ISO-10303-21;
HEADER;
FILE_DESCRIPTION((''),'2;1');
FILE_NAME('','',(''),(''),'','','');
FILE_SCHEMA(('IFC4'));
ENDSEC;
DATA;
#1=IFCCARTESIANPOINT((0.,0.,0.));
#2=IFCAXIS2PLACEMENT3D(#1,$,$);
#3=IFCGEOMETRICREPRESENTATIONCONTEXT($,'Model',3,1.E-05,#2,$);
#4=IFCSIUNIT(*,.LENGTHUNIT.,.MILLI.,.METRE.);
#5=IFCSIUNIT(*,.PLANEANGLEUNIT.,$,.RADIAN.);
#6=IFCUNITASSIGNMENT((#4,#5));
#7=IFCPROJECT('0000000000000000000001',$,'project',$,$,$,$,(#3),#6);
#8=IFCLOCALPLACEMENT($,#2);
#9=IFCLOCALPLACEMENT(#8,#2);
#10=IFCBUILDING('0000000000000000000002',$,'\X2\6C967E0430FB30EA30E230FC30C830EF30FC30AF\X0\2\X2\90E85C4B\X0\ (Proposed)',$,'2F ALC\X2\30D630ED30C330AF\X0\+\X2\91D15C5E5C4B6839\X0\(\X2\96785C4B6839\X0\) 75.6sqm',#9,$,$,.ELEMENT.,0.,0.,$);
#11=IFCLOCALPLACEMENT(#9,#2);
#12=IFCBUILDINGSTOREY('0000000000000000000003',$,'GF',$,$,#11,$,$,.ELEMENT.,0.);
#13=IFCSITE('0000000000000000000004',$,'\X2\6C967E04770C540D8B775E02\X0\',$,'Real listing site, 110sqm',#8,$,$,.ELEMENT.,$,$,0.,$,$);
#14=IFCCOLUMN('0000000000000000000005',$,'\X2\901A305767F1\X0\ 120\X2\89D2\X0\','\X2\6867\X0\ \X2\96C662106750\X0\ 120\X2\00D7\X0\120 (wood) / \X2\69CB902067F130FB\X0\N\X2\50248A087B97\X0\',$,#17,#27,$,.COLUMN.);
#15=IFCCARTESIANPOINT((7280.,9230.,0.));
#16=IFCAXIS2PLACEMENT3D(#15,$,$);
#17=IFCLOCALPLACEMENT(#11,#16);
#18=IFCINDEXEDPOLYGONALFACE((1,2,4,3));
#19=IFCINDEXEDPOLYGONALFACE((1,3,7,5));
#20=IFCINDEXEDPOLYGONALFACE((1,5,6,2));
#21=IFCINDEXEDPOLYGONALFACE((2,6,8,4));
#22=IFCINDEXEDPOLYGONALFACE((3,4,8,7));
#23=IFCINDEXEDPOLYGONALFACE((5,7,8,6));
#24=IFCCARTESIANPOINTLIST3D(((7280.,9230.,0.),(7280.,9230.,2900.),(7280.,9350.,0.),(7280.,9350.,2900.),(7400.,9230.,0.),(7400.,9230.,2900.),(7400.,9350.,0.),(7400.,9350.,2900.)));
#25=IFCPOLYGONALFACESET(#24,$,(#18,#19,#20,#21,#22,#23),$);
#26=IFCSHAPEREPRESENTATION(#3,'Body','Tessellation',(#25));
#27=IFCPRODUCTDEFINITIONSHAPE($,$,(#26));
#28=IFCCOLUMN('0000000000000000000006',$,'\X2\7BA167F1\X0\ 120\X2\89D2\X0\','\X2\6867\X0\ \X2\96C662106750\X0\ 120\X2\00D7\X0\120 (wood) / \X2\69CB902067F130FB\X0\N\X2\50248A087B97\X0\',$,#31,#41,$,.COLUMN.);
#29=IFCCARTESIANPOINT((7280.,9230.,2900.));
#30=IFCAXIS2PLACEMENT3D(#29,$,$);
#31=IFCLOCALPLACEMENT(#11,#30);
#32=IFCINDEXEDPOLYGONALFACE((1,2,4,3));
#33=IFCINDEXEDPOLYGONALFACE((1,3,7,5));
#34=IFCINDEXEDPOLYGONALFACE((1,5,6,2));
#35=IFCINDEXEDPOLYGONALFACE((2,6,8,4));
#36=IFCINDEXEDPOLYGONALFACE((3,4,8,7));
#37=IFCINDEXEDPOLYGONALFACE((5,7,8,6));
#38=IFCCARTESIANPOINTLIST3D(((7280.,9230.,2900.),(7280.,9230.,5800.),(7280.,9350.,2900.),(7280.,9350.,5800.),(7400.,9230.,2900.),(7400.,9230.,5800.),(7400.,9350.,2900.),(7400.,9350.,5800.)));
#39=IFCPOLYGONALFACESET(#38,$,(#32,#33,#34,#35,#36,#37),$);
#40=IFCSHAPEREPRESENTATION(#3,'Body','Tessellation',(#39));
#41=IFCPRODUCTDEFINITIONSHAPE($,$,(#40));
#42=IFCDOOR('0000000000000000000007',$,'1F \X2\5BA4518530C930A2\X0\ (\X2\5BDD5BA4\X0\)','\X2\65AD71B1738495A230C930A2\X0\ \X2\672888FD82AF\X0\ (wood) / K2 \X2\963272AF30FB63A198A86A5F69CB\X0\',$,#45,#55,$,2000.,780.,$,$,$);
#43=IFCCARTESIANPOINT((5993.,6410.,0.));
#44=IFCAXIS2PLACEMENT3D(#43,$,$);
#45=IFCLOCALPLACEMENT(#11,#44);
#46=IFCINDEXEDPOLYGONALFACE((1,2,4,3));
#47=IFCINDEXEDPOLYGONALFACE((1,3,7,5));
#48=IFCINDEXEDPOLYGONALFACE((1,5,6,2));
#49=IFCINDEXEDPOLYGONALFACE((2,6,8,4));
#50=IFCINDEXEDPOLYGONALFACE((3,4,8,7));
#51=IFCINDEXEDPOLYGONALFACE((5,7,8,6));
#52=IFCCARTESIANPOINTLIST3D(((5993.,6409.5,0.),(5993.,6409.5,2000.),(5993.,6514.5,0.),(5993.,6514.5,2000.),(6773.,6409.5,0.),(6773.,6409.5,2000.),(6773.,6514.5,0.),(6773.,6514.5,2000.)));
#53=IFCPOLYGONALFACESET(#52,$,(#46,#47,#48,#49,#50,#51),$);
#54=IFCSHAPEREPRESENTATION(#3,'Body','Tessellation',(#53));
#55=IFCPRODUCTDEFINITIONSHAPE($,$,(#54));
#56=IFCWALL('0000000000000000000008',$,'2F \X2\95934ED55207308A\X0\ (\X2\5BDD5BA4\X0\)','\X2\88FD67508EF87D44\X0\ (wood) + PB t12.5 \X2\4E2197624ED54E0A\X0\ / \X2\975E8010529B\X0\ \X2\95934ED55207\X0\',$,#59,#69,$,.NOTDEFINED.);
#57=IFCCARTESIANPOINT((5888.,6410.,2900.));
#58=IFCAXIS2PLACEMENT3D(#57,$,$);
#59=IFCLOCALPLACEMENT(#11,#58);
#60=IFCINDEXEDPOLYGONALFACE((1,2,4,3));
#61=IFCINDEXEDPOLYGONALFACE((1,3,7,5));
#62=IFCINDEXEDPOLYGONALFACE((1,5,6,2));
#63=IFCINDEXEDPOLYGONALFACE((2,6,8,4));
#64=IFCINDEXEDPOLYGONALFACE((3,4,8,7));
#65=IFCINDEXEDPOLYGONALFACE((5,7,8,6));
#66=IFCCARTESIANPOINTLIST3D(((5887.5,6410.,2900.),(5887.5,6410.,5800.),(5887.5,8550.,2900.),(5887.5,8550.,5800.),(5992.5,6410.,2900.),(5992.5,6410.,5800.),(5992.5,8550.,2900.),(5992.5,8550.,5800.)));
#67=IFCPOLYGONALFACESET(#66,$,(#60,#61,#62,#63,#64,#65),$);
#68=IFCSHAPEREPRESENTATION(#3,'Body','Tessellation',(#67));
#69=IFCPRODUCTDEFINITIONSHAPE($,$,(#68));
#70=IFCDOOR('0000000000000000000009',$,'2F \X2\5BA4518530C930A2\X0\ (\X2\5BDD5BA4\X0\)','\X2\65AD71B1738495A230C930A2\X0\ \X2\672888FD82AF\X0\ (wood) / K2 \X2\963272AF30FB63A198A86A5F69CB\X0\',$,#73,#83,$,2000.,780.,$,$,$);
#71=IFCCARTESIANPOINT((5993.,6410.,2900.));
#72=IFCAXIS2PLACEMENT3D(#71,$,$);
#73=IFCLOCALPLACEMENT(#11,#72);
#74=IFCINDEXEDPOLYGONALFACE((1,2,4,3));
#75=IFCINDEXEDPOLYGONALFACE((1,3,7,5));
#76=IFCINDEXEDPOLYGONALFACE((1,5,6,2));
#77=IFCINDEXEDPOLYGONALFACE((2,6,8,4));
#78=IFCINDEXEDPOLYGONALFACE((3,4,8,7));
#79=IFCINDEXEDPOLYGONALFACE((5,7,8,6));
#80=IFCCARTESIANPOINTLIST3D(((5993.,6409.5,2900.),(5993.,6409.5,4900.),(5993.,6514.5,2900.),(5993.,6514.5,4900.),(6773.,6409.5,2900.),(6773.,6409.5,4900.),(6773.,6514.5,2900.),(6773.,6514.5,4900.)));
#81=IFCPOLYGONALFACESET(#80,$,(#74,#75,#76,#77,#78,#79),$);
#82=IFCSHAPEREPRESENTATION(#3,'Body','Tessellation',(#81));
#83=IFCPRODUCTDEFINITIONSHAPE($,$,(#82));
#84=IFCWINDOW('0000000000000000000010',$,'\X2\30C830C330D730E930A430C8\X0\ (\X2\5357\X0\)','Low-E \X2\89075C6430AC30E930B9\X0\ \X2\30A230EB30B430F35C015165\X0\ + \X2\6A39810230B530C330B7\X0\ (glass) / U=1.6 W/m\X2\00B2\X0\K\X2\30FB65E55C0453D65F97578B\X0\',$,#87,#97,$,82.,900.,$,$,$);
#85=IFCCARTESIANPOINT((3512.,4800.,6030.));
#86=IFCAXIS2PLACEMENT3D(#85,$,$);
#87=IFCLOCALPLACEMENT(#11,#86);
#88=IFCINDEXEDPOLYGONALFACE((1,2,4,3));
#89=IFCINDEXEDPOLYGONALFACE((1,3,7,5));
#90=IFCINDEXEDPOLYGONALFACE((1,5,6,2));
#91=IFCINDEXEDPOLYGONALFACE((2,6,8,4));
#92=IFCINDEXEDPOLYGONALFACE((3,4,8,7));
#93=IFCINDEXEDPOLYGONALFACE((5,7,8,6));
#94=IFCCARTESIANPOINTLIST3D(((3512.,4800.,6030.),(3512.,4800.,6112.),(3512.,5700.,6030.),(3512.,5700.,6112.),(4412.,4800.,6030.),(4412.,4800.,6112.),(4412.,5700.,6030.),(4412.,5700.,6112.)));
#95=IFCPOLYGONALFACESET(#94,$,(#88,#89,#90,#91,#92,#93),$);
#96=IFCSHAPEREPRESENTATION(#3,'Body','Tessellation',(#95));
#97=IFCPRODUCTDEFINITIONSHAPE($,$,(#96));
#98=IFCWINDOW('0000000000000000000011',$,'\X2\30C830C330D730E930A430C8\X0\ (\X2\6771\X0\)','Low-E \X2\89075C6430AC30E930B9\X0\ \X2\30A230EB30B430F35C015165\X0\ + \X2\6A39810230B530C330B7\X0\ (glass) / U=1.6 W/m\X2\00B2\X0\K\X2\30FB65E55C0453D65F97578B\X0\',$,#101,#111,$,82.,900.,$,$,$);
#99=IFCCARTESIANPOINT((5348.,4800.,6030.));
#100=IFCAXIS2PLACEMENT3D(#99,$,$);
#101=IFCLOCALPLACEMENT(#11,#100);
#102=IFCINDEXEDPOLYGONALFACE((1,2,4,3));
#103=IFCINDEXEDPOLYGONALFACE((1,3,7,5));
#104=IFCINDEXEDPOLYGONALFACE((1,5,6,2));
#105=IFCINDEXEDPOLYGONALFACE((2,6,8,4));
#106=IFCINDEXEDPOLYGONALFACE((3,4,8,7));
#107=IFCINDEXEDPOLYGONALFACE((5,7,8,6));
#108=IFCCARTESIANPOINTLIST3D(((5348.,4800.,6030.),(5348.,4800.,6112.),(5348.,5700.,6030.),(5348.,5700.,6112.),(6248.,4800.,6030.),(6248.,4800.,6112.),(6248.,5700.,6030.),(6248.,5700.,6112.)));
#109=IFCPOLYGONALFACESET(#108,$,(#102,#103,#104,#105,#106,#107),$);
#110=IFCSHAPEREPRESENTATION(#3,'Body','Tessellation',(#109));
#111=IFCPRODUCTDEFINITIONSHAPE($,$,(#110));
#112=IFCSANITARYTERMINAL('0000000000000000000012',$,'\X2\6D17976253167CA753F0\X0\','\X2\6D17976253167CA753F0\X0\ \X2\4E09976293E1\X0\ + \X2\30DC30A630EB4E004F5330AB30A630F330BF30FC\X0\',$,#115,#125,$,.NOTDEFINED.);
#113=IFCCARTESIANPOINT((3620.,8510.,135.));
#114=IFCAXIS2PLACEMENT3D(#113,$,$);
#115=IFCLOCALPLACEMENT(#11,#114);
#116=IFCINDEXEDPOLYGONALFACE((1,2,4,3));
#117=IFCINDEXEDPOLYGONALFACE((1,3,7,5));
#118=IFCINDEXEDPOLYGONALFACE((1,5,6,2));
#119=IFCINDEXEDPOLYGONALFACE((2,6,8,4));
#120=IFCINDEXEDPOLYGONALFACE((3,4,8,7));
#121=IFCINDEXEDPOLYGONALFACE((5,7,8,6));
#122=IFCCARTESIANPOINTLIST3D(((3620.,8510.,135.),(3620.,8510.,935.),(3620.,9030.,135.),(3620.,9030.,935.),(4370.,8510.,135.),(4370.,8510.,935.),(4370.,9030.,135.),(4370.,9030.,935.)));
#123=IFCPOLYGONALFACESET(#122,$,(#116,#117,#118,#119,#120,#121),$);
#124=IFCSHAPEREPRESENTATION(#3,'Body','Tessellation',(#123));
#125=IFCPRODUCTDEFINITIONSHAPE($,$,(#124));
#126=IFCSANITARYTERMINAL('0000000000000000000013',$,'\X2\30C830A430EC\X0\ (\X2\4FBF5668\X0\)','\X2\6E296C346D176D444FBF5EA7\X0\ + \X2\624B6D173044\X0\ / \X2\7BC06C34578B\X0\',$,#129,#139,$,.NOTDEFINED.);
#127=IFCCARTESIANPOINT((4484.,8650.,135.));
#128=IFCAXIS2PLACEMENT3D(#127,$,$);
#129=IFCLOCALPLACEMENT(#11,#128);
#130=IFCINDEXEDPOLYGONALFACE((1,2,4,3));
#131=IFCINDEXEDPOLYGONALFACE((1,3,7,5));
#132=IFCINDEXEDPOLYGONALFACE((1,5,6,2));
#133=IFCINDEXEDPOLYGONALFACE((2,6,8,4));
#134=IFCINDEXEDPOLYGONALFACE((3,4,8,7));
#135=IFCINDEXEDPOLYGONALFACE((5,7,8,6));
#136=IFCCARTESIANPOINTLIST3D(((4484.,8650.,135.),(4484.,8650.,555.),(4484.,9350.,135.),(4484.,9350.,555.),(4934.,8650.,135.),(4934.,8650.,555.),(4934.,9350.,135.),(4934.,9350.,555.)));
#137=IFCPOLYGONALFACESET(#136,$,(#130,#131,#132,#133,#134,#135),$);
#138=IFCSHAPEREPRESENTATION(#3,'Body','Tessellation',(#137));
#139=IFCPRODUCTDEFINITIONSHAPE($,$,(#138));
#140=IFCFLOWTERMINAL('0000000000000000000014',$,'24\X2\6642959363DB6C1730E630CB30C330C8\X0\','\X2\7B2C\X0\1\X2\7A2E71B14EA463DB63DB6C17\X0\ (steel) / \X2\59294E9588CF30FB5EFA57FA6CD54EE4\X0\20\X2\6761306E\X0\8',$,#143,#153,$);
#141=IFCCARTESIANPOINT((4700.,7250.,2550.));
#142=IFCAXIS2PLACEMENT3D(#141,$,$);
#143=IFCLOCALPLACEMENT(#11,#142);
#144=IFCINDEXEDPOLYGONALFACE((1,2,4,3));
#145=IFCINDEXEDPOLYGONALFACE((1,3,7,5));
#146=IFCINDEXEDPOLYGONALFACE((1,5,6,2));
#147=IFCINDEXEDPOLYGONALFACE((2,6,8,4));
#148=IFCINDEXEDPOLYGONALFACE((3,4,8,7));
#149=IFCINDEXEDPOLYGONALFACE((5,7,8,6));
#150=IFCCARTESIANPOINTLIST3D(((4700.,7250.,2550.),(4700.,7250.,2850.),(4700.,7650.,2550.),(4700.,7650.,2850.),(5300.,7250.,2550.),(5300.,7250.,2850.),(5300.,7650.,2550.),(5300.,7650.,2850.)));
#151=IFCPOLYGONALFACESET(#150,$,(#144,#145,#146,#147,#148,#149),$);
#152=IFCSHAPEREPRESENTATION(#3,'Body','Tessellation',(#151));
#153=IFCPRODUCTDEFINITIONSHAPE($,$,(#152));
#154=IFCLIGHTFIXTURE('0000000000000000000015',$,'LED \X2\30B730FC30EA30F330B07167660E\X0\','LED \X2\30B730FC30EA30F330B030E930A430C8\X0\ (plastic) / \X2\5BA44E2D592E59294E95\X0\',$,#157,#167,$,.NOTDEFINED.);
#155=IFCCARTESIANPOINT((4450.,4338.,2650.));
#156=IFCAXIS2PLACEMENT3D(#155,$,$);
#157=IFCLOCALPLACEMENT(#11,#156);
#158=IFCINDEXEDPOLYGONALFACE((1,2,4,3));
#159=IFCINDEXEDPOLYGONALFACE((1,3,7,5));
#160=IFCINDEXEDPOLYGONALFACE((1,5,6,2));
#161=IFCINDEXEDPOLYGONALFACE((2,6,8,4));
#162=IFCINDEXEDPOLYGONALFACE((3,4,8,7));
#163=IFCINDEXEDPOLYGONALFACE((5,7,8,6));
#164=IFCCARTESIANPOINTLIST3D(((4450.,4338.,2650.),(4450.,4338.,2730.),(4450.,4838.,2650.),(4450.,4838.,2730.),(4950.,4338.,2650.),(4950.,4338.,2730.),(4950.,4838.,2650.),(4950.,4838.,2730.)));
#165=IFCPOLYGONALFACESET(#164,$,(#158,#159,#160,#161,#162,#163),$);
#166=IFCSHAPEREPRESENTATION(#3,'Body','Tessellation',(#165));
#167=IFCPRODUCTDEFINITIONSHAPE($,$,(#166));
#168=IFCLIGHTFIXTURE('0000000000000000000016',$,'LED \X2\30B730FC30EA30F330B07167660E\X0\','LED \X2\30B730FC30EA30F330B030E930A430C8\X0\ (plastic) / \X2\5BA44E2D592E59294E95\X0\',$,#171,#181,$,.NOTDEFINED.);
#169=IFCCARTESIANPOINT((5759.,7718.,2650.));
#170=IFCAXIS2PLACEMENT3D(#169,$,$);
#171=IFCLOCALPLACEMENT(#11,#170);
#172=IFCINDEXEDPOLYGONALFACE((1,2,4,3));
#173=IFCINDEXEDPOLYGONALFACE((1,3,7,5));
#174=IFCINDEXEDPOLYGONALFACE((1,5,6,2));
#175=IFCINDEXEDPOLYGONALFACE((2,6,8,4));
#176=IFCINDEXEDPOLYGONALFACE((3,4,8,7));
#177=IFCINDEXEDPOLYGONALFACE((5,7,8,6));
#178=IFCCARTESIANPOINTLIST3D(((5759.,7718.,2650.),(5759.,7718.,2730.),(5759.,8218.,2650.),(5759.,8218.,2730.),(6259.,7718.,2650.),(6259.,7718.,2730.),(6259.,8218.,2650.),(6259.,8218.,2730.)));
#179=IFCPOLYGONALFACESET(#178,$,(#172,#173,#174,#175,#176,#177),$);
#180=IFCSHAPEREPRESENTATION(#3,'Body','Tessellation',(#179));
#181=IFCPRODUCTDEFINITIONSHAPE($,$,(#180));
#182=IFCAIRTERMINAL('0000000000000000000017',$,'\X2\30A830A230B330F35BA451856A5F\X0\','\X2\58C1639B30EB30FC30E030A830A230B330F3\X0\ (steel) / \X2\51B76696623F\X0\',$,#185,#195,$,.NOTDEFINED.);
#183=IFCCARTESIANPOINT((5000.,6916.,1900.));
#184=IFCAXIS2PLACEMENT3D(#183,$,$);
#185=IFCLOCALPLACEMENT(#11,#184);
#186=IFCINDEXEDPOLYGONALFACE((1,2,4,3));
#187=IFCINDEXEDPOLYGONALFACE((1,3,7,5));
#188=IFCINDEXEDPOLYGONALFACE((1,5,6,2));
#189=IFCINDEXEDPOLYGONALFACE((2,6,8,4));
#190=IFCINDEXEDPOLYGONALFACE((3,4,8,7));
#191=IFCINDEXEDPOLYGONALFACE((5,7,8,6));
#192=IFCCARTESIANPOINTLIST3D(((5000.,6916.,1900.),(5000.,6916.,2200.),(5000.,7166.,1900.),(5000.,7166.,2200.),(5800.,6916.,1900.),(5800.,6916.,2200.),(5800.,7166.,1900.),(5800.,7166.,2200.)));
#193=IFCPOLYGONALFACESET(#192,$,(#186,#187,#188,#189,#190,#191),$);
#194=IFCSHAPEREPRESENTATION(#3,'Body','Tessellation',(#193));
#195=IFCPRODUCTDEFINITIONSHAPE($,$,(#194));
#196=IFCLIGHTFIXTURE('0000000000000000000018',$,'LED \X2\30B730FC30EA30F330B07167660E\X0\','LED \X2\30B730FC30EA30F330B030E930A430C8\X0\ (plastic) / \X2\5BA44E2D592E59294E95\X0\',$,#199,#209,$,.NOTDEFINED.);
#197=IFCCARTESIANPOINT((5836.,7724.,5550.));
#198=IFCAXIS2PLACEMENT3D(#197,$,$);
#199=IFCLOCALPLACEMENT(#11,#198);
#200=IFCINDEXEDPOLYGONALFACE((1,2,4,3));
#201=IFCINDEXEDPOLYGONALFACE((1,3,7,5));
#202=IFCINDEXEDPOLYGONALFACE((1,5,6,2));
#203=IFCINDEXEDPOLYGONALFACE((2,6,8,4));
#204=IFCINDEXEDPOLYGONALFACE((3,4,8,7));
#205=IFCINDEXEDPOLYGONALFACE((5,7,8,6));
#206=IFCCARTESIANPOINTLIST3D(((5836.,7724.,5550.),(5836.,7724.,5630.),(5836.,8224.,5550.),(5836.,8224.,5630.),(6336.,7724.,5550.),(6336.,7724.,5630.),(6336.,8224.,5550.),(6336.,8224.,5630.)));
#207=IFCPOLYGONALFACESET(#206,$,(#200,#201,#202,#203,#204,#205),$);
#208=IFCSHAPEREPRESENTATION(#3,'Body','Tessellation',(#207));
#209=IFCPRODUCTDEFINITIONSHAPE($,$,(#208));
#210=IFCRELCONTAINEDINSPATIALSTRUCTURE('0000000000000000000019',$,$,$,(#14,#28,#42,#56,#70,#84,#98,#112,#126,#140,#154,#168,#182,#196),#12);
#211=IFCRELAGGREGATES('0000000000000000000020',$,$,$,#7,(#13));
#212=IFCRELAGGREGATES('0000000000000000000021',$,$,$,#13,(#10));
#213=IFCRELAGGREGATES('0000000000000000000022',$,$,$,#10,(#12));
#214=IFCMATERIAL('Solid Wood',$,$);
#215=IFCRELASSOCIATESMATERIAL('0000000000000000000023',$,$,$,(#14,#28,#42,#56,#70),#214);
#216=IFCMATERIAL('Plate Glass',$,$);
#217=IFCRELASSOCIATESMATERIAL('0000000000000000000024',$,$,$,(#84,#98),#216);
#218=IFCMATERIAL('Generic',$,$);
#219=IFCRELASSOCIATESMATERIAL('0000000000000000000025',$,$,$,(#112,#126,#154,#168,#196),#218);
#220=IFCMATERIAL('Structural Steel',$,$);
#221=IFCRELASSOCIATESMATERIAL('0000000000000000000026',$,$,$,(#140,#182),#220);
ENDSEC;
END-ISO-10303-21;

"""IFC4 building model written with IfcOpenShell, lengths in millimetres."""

from ifc_helpers import new_model, si_unit, frame, frame_2d, origin, place, context, project, spatial, rectangle, extrude, material, element, save


model = new_model("IFC4")

# Units and contexts
model_context = context("Model", 3, precision=1e-05, world=origin())
ifc_project = project(units=[si_unit("LENGTHUNIT", "METRE", prefix="MILLI"), si_unit("PLANEANGLEUNIT", "RADIAN")], contexts=[model_context])

# Site, building, storey
site_placement = place(None, origin())
site = spatial("IfcSite", under=ifc_project, at=site_placement, Name="沖縄県名護市", ObjectType="Real listing site, 110sqm", CompositionType="ELEMENT", RefElevation=0.0)
building_placement = place(site_placement, origin())
building = spatial("IfcBuilding", under=site, at=building_placement, Name="沖縄・リモートワーク2部屋 (Proposed)", ObjectType="2F ALCブロック+金属屋根(陸屋根) 75.6sqm", CompositionType="ELEMENT", ElevationOfRefHeight=0.0, ElevationOfTerrain=0.0)
storey_placement = place(building_placement, origin())
storey = spatial("IfcBuildingStorey", under=building, at=storey_placement, Name="GF", CompositionType="ELEMENT", Elevation=0.0)

# Columns
ifc_material_1 = material(Name="Solid Wood")
column_1_placement = place(storey_placement, frame((7280.0, 9230.0, 0.0)))
element("IfcColumn", 1, at=column_1_placement, inside=storey, material=ifc_material_1, Name="通し柱 120角", Description="桧 集成材 120×120 (wood) / 構造柱・N値計算", PredefinedType="COLUMN", context=model_context, shape_type="SweptSolid", body=[
    extrude(rectangle(XDim=120.0, YDim=120.0, at=frame_2d((60.0, 60.0))), frame((7280.0, 9230.0, 0.0)), (0.0, 0.0, 1.0), 2900.0),
])
column_2_placement = place(storey_placement, frame((7280.0, 9230.0, 2900.0)))
element("IfcColumn", 2, at=column_2_placement, inside=storey, material=ifc_material_1, Name="管柱 120角", Description="桧 集成材 120×120 (wood) / 構造柱・N値計算", PredefinedType="COLUMN", context=model_context, shape_type="SweptSolid", body=[
    extrude(rectangle(XDim=120.0, YDim=120.0, at=frame_2d((60.0, 60.0))), frame((7280.0, 9230.0, 2900.0)), (0.0, 0.0, 1.0), 2900.0),
])

# Door
door_1_placement = place(storey_placement, frame((5993.0, 6410.0, 0.0)))
element("IfcDoor", 3, at=door_1_placement, inside=storey, material=ifc_material_1, Name="1F 室内ドア (寝室)", Description="断熱玄関ドア 木製芯 (wood) / K2 防犯・採風機構", OverallHeight=2000.0, OverallWidth=780.0, context=model_context, shape_type="SweptSolid", body=[
    extrude(rectangle(XDim=780.0, YDim=105.0, at=frame_2d((390.0, 52.0))), frame((5993.0, 6410.0, 0.0)), (0.0, 0.0, 1.0), 2000.0),
])

# Wall
wall_1_placement = place(storey_placement, frame((5888.0, 6410.0, 2900.0)))
element("IfcWall", 4, at=wall_1_placement, inside=storey, material=ifc_material_1, Name="2F 間仕切り (寝室)", Description="製材軸組 (wood) + PB t12.5 両面仕上 / 非耐力 間仕切", PredefinedType="NOTDEFINED", context=model_context, shape_type="SweptSolid", body=[
    extrude(rectangle(XDim=105.0, YDim=2140.0, at=frame_2d((52.0, 1070.0))), frame((5888.0, 6410.0, 2900.0)), (0.0, 0.0, 1.0), 2900.0),
])

# Door
door_2_placement = place(storey_placement, frame((5993.0, 6410.0, 2900.0)))
element("IfcDoor", 5, at=door_2_placement, inside=storey, material=ifc_material_1, Name="2F 室内ドア (寝室)", Description="断熱玄関ドア 木製芯 (wood) / K2 防犯・採風機構", OverallHeight=2000.0, OverallWidth=780.0, context=model_context, shape_type="SweptSolid", body=[
    extrude(rectangle(XDim=780.0, YDim=105.0, at=frame_2d((390.0, 52.0))), frame((5993.0, 6410.0, 2900.0)), (0.0, 0.0, 1.0), 2000.0),
])

# Windows
ifc_material_2 = material(Name="Plate Glass")
window_1_placement = place(storey_placement, frame((3512.0, 4800.0, 6030.0)))
element("IfcWindow", 6, at=window_1_placement, inside=storey, material=ifc_material_2, Name="トップライト (南)", Description="Low-E 複層ガラス アルゴン封入 + 樹脂サッシ (glass) / U=1.6 W/m²K・日射取得型", OverallHeight=82.0, OverallWidth=900.0, context=model_context, shape_type="SweptSolid", body=[
    extrude(rectangle(XDim=900.0, YDim=900.0, at=frame_2d((450.0, 450.0))), frame((3512.0, 4800.0, 6030.0)), (0.0, 0.0, 1.0), 82.0),
])
window_2_placement = place(storey_placement, frame((5348.0, 4800.0, 6030.0)))
element("IfcWindow", 7, at=window_2_placement, inside=storey, material=ifc_material_2, Name="トップライト (東)", Description="Low-E 複層ガラス アルゴン封入 + 樹脂サッシ (glass) / U=1.6 W/m²K・日射取得型", OverallHeight=82.0, OverallWidth=900.0, context=model_context, shape_type="SweptSolid", body=[
    extrude(rectangle(XDim=900.0, YDim=900.0, at=frame_2d((450.0, 450.0))), frame((5348.0, 4800.0, 6030.0)), (0.0, 0.0, 1.0), 82.0),
])

# Sanitary terminals
ifc_material_3 = material(Name="Generic")
sanitary_terminal_1_placement = place(storey_placement, frame((3620.0, 8510.0, 135.0)))
element("IfcSanitaryTerminal", 8, at=sanitary_terminal_1_placement, inside=storey, material=ifc_material_3, Name="洗面化粧台", Description="洗面化粧台 三面鏡 + ボウル一体カウンター", PredefinedType="NOTDEFINED", context=model_context, shape_type="SweptSolid", body=[
    extrude(rectangle(XDim=750.0, YDim=520.0, at=frame_2d((375.0, 260.0))), frame((3620.0, 8510.0, 135.0)), (0.0, 0.0, 1.0), 800.0),
])
sanitary_terminal_2_placement = place(storey_placement, frame((4484.0, 8650.0, 135.0)))
element("IfcSanitaryTerminal", 9, at=sanitary_terminal_2_placement, inside=storey, material=ifc_material_3, Name="トイレ (便器)", Description="温水洗浄便座 + 手洗い / 節水型", PredefinedType="NOTDEFINED", context=model_context, shape_type="SweptSolid", body=[
    extrude(rectangle(XDim=450.0, YDim=700.0, at=frame_2d((225.0, 350.0))), frame((4484.0, 8650.0, 135.0)), (0.0, 0.0, 1.0), 420.0),
])

# Flow terminal
ifc_material_4 = material(Name="Structural Steel")
flow_terminal_placement = place(storey_placement, frame((4700.0, 7250.0, 2550.0)))
element("IfcFlowTerminal", 10, at=flow_terminal_placement, inside=storey, material=ifc_material_4, Name="24時間換気ユニット", Description="第1種熱交換換気 (steel) / 天井裏・建基法令20条の8", context=model_context, shape_type="SweptSolid", body=[
    extrude(rectangle(XDim=600.0, YDim=400.0, at=frame_2d((300.0, 200.0))), frame((4700.0, 7250.0, 2550.0)), (0.0, 0.0, 1.0), 300.0),
])

# Light fixtures
light_fixture_1_placement = place(storey_placement, frame((4450.0, 4338.0, 2650.0)))
element("IfcLightFixture", 11, at=light_fixture_1_placement, inside=storey, material=ifc_material_3, Name="LED シーリング照明", Description="LED シーリングライト (plastic) / 室中央天井", PredefinedType="NOTDEFINED", context=model_context, shape_type="SweptSolid", body=[
    extrude(rectangle(XDim=500.0, YDim=500.0, at=frame_2d((250.0, 250.0))), frame((4450.0, 4338.0, 2650.0)), (0.0, 0.0, 1.0), 80.0),
])
light_fixture_2_placement = place(storey_placement, frame((5759.0, 7718.0, 2650.0)))
element("IfcLightFixture", 12, at=light_fixture_2_placement, inside=storey, material=ifc_material_3, Name="LED シーリング照明", Description="LED シーリングライト (plastic) / 室中央天井", PredefinedType="NOTDEFINED", context=model_context, shape_type="SweptSolid", body=[
    extrude(rectangle(XDim=500.0, YDim=500.0, at=frame_2d((250.0, 250.0))), frame((5759.0, 7718.0, 2650.0)), (0.0, 0.0, 1.0), 80.0),
])

# Air terminal
air_terminal_placement = place(storey_placement, frame((5000.0, 6916.0, 1900.0)))
element("IfcAirTerminal", 13, at=air_terminal_placement, inside=storey, material=ifc_material_4, Name="エアコン室内機", Description="壁掛ルームエアコン (steel) / 冷暖房", PredefinedType="NOTDEFINED", context=model_context, shape_type="SweptSolid", body=[
    extrude(rectangle(XDim=800.0, YDim=250.0, at=frame_2d((400.0, 125.0))), frame((5000.0, 6916.0, 1900.0)), (0.0, 0.0, 1.0), 300.0),
])

# Light fixture
light_fixture_3_placement = place(storey_placement, frame((5836.0, 7724.0, 5550.0)))
element("IfcLightFixture", 14, at=light_fixture_3_placement, inside=storey, material=ifc_material_3, Name="LED シーリング照明", Description="LED シーリングライト (plastic) / 室中央天井", PredefinedType="NOTDEFINED", context=model_context, shape_type="SweptSolid", body=[
    extrude(rectangle(XDim=500.0, YDim=500.0, at=frame_2d((250.0, 250.0))), frame((5836.0, 7724.0, 5550.0)), (0.0, 0.0, 1.0), 80.0),
])

save(model, "model.ifc")
